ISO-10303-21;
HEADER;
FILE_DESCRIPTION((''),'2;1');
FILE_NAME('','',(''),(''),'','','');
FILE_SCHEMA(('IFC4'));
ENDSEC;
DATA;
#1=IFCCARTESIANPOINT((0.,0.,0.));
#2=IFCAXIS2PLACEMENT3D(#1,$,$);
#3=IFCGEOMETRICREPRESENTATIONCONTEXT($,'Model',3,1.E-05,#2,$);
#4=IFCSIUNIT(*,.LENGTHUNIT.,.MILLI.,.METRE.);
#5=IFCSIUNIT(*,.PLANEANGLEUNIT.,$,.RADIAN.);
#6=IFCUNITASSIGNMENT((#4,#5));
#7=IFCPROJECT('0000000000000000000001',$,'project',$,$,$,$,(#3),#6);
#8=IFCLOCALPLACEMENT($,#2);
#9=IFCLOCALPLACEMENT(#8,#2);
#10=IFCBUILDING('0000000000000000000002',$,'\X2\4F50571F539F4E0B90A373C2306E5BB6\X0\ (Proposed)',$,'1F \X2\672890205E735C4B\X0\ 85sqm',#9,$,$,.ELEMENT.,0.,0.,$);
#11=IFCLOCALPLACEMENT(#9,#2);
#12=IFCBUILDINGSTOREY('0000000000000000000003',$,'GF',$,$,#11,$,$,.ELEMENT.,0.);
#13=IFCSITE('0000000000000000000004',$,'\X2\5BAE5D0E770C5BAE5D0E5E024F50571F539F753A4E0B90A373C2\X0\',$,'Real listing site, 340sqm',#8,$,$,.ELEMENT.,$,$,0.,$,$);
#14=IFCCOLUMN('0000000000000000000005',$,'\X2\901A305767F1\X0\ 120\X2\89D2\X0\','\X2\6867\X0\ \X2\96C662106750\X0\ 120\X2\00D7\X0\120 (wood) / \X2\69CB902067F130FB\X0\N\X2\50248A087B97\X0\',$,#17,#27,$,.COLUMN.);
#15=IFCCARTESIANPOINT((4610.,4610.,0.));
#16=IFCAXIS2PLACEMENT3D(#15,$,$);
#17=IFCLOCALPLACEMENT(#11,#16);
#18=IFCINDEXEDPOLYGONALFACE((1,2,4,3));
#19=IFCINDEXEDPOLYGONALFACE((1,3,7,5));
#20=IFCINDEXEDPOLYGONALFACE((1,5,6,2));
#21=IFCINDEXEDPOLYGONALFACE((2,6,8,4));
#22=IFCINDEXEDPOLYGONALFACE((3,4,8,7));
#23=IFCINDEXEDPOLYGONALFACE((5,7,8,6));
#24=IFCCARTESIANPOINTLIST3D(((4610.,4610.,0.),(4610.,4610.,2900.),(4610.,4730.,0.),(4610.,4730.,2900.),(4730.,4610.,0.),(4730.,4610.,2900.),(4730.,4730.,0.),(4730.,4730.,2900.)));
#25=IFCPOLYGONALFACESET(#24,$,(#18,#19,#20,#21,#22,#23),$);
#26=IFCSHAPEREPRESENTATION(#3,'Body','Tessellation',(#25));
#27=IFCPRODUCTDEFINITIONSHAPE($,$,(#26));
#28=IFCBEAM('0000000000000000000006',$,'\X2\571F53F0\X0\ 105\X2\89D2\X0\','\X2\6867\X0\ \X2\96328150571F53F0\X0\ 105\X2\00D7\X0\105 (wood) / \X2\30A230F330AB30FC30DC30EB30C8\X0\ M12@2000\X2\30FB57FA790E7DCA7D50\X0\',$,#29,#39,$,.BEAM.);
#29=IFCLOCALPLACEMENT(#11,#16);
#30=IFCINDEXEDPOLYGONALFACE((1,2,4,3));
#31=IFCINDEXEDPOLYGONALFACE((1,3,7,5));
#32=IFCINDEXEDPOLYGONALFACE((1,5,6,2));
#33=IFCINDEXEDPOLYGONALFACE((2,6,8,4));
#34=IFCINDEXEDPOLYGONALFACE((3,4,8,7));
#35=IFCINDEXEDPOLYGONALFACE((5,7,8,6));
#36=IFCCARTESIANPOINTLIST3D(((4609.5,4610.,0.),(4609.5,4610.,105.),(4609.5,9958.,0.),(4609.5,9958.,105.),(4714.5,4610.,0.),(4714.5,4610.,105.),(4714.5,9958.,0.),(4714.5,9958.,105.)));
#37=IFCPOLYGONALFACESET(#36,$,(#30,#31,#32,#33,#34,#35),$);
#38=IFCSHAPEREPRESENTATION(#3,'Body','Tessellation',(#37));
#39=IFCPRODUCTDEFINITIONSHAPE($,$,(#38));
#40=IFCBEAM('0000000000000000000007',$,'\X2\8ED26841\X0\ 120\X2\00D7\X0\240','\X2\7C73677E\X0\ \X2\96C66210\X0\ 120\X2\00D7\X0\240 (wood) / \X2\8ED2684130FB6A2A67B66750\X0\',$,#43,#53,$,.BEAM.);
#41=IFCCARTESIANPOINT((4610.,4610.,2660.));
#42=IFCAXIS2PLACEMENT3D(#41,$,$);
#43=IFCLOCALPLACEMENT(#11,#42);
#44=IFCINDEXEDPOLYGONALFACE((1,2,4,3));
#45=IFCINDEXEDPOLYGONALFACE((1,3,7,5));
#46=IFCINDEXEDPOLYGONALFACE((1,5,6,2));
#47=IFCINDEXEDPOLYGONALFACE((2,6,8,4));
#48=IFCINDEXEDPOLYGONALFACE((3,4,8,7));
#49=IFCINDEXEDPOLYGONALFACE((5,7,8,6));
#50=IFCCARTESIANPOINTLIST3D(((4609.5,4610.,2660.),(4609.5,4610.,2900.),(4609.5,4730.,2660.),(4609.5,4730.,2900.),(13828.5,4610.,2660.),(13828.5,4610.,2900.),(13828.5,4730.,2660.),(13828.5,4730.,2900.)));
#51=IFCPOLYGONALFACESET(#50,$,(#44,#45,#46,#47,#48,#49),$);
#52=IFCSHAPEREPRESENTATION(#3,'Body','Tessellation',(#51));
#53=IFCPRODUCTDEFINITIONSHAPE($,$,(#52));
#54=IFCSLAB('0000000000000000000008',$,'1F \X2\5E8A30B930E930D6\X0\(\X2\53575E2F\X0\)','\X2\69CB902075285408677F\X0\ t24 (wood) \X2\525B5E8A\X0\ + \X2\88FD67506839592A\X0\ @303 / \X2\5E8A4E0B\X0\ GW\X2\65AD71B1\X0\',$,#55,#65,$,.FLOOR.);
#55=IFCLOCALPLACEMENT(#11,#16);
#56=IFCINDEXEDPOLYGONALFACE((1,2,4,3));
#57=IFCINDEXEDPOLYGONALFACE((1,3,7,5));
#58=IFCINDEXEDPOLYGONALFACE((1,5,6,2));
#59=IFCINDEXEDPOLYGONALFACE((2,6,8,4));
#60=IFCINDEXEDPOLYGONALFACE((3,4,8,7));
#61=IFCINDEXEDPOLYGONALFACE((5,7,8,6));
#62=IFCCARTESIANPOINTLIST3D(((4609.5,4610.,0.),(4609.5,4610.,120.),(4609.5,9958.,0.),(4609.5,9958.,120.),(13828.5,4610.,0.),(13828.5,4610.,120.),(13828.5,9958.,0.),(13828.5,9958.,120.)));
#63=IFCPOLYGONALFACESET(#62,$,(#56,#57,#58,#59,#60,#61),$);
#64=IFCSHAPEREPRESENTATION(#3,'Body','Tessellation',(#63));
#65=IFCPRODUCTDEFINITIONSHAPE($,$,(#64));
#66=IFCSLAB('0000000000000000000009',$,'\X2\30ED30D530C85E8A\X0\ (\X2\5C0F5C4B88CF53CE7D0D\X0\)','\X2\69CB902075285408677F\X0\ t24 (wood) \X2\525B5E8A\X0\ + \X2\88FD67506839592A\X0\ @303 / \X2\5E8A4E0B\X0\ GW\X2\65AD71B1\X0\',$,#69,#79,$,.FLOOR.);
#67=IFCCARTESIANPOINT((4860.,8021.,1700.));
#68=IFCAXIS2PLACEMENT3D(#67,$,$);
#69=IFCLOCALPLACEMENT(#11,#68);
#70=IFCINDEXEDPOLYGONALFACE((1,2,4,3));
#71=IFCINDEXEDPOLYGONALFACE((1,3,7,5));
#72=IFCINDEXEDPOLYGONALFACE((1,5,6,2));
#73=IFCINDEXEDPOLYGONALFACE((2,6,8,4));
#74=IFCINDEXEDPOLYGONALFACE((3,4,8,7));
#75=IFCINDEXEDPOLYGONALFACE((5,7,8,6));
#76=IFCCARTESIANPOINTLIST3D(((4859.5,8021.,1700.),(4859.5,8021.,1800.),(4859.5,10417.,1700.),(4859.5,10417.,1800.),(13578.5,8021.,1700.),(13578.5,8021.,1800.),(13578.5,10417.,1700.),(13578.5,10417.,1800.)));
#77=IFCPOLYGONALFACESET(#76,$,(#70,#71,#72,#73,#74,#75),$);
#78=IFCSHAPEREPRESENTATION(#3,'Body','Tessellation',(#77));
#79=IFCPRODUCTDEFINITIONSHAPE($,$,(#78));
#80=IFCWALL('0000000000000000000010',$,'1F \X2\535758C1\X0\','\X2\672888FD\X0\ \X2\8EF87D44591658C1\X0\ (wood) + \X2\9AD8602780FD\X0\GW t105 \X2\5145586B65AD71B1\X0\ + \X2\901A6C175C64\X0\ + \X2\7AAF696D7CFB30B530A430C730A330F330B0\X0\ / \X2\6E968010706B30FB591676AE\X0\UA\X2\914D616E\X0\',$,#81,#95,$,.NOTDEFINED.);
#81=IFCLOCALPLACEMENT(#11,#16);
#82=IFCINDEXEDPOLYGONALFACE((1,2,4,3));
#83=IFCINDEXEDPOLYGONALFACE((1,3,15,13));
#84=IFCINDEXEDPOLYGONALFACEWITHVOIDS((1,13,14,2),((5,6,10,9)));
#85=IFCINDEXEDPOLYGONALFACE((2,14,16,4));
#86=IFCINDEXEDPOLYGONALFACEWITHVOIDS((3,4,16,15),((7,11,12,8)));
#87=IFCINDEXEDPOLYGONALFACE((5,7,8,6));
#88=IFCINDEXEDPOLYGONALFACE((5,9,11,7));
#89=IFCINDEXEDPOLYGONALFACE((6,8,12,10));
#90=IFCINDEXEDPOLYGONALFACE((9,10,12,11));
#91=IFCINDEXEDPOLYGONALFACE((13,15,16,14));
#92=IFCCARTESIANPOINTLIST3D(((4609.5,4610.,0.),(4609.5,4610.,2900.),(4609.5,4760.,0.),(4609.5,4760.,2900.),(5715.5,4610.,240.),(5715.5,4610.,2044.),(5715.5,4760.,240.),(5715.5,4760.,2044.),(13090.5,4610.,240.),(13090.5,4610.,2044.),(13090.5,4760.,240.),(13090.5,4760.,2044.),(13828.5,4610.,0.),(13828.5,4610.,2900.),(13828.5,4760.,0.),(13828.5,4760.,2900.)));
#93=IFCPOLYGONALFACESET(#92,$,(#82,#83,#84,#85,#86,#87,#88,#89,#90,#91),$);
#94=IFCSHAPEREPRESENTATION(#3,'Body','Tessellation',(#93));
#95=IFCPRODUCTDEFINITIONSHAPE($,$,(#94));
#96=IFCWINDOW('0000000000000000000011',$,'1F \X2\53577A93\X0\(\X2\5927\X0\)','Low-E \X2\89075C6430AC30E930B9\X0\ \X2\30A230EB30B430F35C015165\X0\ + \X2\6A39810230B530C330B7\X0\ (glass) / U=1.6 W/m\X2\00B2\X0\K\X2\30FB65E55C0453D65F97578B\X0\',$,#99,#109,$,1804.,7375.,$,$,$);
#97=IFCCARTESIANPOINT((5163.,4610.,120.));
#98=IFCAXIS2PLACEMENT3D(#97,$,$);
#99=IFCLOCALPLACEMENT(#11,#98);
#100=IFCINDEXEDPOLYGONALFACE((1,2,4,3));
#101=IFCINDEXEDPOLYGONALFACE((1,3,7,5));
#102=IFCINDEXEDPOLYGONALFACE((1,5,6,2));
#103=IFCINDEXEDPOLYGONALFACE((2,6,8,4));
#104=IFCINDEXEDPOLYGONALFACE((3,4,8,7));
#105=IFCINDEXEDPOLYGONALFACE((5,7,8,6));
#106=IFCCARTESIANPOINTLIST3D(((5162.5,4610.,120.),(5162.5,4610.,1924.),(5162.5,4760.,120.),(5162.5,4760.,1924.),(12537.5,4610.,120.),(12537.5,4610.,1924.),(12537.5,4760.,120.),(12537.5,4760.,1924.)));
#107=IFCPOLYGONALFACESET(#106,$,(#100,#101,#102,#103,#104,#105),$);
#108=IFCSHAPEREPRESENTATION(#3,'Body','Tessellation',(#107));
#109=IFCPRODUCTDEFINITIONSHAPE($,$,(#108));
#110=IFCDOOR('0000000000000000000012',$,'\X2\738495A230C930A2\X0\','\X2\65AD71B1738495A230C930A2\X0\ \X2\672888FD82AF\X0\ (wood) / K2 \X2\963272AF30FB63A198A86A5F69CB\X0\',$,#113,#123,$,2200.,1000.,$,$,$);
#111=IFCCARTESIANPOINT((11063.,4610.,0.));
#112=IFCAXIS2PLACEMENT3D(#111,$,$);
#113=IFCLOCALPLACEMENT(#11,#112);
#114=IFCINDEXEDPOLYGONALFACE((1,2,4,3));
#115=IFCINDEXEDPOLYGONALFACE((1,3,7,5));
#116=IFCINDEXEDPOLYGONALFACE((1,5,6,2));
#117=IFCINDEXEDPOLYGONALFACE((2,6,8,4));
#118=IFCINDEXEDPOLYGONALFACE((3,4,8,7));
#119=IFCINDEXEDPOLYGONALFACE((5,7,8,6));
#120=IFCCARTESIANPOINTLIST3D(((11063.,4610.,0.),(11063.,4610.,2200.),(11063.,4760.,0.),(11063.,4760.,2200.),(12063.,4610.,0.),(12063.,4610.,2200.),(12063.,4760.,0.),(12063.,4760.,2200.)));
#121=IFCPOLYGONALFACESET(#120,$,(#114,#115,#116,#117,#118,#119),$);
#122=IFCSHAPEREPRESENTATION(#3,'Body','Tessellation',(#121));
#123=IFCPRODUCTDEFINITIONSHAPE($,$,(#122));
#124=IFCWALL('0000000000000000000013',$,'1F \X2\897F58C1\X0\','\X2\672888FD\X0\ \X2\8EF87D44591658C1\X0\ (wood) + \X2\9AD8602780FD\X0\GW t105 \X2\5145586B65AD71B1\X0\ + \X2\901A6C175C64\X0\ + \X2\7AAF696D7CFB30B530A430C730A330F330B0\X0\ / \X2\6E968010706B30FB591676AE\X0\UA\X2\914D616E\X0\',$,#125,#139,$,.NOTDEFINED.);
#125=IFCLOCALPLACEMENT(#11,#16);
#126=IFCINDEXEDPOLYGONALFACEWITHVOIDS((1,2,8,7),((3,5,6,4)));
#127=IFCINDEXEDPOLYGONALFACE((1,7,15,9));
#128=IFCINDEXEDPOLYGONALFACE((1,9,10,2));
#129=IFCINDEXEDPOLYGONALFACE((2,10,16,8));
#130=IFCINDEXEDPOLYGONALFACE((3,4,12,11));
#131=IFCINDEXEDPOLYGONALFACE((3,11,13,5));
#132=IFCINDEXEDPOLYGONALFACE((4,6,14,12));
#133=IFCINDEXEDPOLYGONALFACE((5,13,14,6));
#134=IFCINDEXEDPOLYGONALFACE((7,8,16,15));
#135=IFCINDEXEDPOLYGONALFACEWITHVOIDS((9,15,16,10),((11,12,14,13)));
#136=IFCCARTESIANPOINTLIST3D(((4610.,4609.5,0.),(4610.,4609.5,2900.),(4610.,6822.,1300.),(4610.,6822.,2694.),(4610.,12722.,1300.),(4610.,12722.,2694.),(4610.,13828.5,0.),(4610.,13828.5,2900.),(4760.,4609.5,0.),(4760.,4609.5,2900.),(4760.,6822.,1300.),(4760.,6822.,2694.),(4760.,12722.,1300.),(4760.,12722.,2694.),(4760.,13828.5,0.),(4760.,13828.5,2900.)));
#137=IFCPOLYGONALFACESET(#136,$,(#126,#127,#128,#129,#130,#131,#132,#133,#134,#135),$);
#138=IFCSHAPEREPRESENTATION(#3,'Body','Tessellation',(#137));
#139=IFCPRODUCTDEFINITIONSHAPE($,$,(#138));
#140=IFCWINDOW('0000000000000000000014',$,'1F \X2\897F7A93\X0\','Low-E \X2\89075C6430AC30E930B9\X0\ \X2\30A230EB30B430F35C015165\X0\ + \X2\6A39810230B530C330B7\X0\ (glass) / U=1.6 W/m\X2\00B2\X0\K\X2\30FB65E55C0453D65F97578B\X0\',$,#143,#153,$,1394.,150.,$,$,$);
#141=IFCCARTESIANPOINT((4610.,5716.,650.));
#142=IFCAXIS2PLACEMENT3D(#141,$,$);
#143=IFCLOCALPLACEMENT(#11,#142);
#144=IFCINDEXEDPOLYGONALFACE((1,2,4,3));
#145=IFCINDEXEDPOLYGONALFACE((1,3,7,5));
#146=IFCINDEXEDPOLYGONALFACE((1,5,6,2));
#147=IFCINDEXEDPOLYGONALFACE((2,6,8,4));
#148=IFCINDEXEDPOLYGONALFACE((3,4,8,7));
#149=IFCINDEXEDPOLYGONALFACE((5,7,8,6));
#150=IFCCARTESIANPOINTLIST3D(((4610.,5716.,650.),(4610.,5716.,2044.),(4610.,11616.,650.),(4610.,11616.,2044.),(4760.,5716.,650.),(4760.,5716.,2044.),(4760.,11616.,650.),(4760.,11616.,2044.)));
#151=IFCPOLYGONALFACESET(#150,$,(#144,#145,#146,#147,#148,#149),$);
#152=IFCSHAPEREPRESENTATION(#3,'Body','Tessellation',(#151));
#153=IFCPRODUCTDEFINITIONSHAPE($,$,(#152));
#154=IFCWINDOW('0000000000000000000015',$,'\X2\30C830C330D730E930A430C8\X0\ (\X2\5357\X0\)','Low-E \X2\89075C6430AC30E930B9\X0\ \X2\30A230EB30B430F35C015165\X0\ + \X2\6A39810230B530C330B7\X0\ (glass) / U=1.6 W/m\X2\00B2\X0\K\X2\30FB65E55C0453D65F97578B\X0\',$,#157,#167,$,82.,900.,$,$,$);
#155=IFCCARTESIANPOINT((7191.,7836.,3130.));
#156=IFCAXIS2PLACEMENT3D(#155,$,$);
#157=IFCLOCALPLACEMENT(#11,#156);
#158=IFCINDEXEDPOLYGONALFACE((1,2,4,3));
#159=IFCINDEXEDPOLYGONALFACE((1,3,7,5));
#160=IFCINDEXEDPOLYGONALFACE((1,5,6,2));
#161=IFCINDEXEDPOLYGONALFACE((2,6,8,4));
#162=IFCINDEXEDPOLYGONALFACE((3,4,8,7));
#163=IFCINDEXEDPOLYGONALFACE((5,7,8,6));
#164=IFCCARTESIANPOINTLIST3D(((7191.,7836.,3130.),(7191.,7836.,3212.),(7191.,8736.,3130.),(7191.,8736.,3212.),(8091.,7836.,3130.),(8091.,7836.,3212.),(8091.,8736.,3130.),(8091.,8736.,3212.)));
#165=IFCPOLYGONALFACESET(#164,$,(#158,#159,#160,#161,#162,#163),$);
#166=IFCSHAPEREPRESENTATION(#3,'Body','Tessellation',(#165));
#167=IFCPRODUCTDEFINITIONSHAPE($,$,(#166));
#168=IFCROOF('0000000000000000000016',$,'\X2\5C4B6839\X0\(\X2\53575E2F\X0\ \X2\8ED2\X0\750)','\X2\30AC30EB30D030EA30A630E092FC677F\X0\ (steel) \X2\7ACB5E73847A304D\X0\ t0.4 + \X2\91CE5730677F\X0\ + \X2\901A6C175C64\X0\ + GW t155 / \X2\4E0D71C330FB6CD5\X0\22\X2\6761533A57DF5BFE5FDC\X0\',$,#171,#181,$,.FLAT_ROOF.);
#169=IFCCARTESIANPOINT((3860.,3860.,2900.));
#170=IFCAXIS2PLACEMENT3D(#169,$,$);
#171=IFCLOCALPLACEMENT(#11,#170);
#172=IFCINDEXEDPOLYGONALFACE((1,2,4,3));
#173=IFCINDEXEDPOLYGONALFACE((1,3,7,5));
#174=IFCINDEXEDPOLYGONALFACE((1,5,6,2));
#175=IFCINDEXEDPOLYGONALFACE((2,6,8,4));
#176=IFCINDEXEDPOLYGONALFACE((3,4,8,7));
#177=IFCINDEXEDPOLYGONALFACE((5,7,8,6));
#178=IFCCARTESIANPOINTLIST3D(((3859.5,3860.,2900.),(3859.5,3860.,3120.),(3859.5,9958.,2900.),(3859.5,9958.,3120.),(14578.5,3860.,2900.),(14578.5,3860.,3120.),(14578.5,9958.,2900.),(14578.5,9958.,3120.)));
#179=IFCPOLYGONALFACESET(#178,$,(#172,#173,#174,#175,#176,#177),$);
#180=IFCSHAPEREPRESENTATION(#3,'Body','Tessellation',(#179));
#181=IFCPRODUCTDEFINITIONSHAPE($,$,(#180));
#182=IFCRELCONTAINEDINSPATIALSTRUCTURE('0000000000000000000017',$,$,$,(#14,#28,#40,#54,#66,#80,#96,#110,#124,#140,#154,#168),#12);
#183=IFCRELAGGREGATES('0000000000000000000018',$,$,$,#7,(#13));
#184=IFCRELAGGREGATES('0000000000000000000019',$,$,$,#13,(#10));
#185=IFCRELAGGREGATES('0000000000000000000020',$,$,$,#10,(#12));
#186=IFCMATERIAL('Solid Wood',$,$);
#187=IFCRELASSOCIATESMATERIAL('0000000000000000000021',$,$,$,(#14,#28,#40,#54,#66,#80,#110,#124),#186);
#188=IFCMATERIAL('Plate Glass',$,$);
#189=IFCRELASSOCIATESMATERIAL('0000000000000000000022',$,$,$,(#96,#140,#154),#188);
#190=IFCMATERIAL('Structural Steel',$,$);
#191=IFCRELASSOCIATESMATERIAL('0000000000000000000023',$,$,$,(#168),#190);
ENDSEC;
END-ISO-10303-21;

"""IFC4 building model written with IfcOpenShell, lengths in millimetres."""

from ifc_helpers import new_model, si_unit, frame, frame_2d, origin, place, context, project, spatial, rectangle, extrude, material, element, fill, save


model = new_model("IFC4")

# Units and contexts
model_context = context("Model", 3, precision=1e-05, world=origin())
ifc_project = project(units=[si_unit("LENGTHUNIT", "METRE", prefix="MILLI"), si_unit("PLANEANGLEUNIT", "RADIAN")], contexts=[model_context])

# Site, building, storey
site_placement = place(None, origin())
site = spatial("IfcSite", under=ifc_project, at=site_placement, Name="宮崎県宮崎市佐土原町下那珂", ObjectType="Real listing site, 340sqm", CompositionType="ELEMENT", RefElevation=0.0)
building_placement = place(site_placement, origin())
building = spatial("IfcBuilding", under=site, at=building_placement, Name="佐土原下那珂の家 (Proposed)", ObjectType="1F 木造平屋 85sqm", CompositionType="ELEMENT", ElevationOfRefHeight=0.0, ElevationOfTerrain=0.0)
storey_placement = place(building_placement, origin())
storey = spatial("IfcBuildingStorey", under=building, at=storey_placement, Name="GF", CompositionType="ELEMENT", Elevation=0.0)

# Column
ifc_material_1 = material(Name="Solid Wood")
column_1_placement = place(storey_placement, frame((4610.0, 4610.0, 0.0)))
element("IfcColumn", 1, at=column_1_placement, inside=storey, material=ifc_material_1, Name="通し柱 120角", Description="桧 集成材 120×120 (wood) / 構造柱・N値計算", PredefinedType="COLUMN", context=model_context, shape_type="SweptSolid", body=[
    extrude(rectangle(XDim=120.0, YDim=120.0, at=frame_2d((60.0, 60.0))), frame((4610.0, 4610.0, 0.0)), (0.0, 0.0, 1.0), 2900.0),
])

# Beams
beam_1_placement = place(storey_placement, frame((4610.0, 4610.0, 0.0)))
element("IfcBeam", 2, at=beam_1_placement, inside=storey, material=ifc_material_1, Name="土台 105角", Description="桧 防腐土台 105×105 (wood) / アンカーボルト M12@2000・基礎緊結", PredefinedType="BEAM", context=model_context, shape_type="SweptSolid", body=[
    extrude(rectangle(XDim=105.0, YDim=5348.0, at=frame_2d((52.0, 2674.0))), frame((4610.0, 4610.0, 0.0)), (0.0, 0.0, 1.0), 105.0),
])
beam_2_placement = place(storey_placement, frame((4610.0, 4610.0, 2660.0)))
element("IfcBeam", 3, at=beam_2_placement, inside=storey, material=ifc_material_1, Name="軒桁 120×240", Description="米松 集成 120×240 (wood) / 軒桁・横架材", PredefinedType="BEAM", context=model_context, shape_type="SweptSolid", body=[
    extrude(rectangle(XDim=9219.0, YDim=120.0, at=frame_2d((4609.0, 60.0))), frame((4610.0, 4610.0, 2660.0)), (0.0, 0.0, 1.0), 240.0),
])

# Slabs
slab_1_placement = place(storey_placement, frame((4610.0, 4610.0, 0.0)))
element("IfcSlab", 4, at=slab_1_placement, inside=storey, material=ifc_material_1, Name="1F 床スラブ(南帯)", Description="構造用合板 t24 (wood) 剛床 + 製材根太 @303 / 床下 GW断熱", PredefinedType="FLOOR", context=model_context, shape_type="SweptSolid", body=[
    extrude(rectangle(XDim=9219.0, YDim=5348.0, at=frame_2d((4609.0, 2674.0))), frame((4610.0, 4610.0, 0.0)), (0.0, 0.0, 1.0), 120.0),
])
slab_2_placement = place(storey_placement, frame((4860.0, 8021.0, 1700.0)))
element("IfcSlab", 5, at=slab_2_placement, inside=storey, material=ifc_material_1, Name="ロフト床 (小屋裏収納)", Description="構造用合板 t24 (wood) 剛床 + 製材根太 @303 / 床下 GW断熱", PredefinedType="FLOOR", context=model_context, shape_type="SweptSolid", body=[
    extrude(rectangle(XDim=8719.0, YDim=2396.0, at=frame_2d((4359.0, 1198.0))), frame((4860.0, 8021.0, 1700.0)), (0.0, 0.0, 1.0), 100.0),
])

# Wall, openings, window, door
wall_1_placement = place(storey_placement, frame((4610.0, 4610.0, 0.0)))
wall_1 = element("IfcWall", 6, at=wall_1_placement, inside=storey, material=ifc_material_1, Name="1F 南壁", Description="木製 軸組外壁 (wood) + 高性能GW t105 充填断熱 + 通気層 + 窯業系サイディング / 準耐火・外皮UA配慮", PredefinedType="NOTDEFINED", context=model_context, shape_type="SweptSolid", body=[
    extrude(rectangle(XDim=9219.0, YDim=150.0, at=frame_2d((4609.0, 75.0))), frame((4610.0, 4610.0, 0.0)), (0.0, 0.0, 1.0), 2900.0),
])
opening_1_placement = place(storey_placement, frame((5163.0, 4610.0, 120.0)))
opening_1 = element("IfcOpeningElement", 7, at=opening_1_placement, cuts=wall_1, PredefinedType="NOTDEFINED", context=model_context, shape_type="SweptSolid", body=[
    extrude(rectangle(XDim=7375.0, YDim=150.0, at=frame_2d((3687.0, 75.0))), frame((5163.0, 4610.0, 120.0)), (0.0, 0.0, 1.0), 1804.0),
])
opening_2_placement = place(storey_placement, frame((11063.0, 4610.0, 0.0)))
opening_2 = element("IfcOpeningElement", 8, at=opening_2_placement, cuts=wall_1, PredefinedType="NOTDEFINED", context=model_context, shape_type="SweptSolid", body=[
    extrude(rectangle(XDim=1000.0, YDim=150.0, at=frame_2d((500.0, 75.0))), frame((11063.0, 4610.0, 0.0)), (0.0, 0.0, 1.0), 2200.0),
])
ifc_material_2 = material(Name="Plate Glass")
window_1_placement = place(storey_placement, frame((5163.0, 4610.0, 120.0)))
window_1 = element("IfcWindow", 9, at=window_1_placement, inside=storey, material=ifc_material_2, Name="1F 南窓(大)", Description="Low-E 複層ガラス アルゴン封入 + 樹脂サッシ (glass) / U=1.6 W/m²K・日射取得型", OverallHeight=1804.0, OverallWidth=7375.0, context=model_context, shape_type="SweptSolid", body=[
    extrude(rectangle(XDim=7375.0, YDim=150.0, at=frame_2d((3687.0, 75.0))), frame((5163.0, 4610.0, 120.0)), (0.0, 0.0, 1.0), 1804.0),
])
fill(opening_1, window_1)
door_1_placement = place(storey_placement, frame((11063.0, 4610.0, 0.0)))
door_1 = element("IfcDoor", 10, at=door_1_placement, inside=storey, material=ifc_material_1, Name="玄関ドア", Description="断熱玄関ドア 木製芯 (wood) / K2 防犯・採風機構", OverallHeight=2200.0, OverallWidth=1000.0, context=model_context, shape_type="SweptSolid", body=[
    extrude(rectangle(XDim=1000.0, YDim=150.0, at=frame_2d((500.0, 75.0))), frame((11063.0, 4610.0, 0.0)), (0.0, 0.0, 1.0), 2200.0),
])
fill(opening_2, door_1)

# Wall, opening, window
wall_2_placement = place(storey_placement, frame((4610.0, 4610.0, 0.0)))
wall_2 = element("IfcWall", 11, at=wall_2_placement, inside=storey, material=ifc_material_1, Name="1F 西壁", Description="木製 軸組外壁 (wood) + 高性能GW t105 充填断熱 + 通気層 + 窯業系サイディング / 準耐火・外皮UA配慮", PredefinedType="NOTDEFINED", context=model_context, shape_type="SweptSolid", body=[
    extrude(rectangle(XDim=150.0, YDim=9219.0, at=frame_2d((75.0, 4609.0))), frame((4610.0, 4610.0, 0.0)), (0.0, 0.0, 1.0), 2900.0),
])
opening_3_placement = place(storey_placement, frame((4610.0, 5716.0, 650.0)))
opening_3 = element("IfcOpeningElement", 12, at=opening_3_placement, cuts=wall_2, PredefinedType="NOTDEFINED", context=model_context, shape_type="SweptSolid", body=[
    extrude(rectangle(XDim=150.0, YDim=5900.0, at=frame_2d((75.0, 2950.0))), frame((4610.0, 5716.0, 650.0)), (0.0, 0.0, 1.0), 1394.0),
])
window_2_placement = place(storey_placement, frame((4610.0, 5716.0, 650.0)))
window_2 = element("IfcWindow", 13, at=window_2_placement, inside=storey, material=ifc_material_2, Name="1F 西窓", Description="Low-E 複層ガラス アルゴン封入 + 樹脂サッシ (glass) / U=1.6 W/m²K・日射取得型", OverallHeight=1394.0, OverallWidth=150.0, context=model_context, shape_type="SweptSolid", body=[
    extrude(rectangle(XDim=150.0, YDim=5900.0, at=frame_2d((75.0, 2950.0))), frame((4610.0, 5716.0, 650.0)), (0.0, 0.0, 1.0), 1394.0),
])
fill(opening_3, window_2)

# Window
window_3_placement = place(storey_placement, frame((7191.0, 7836.0, 3130.0)))
element("IfcWindow", 14, at=window_3_placement, inside=storey, material=ifc_material_2, Name="トップライト (南)", Description="Low-E 複層ガラス アルゴン封入 + 樹脂サッシ (glass) / U=1.6 W/m²K・日射取得型", OverallHeight=82.0, OverallWidth=900.0, context=model_context, shape_type="SweptSolid", body=[
    extrude(rectangle(XDim=900.0, YDim=900.0, at=frame_2d((450.0, 450.0))), frame((7191.0, 7836.0, 3130.0)), (0.0, 0.0, 1.0), 82.0),
])

# Roof
ifc_material_3 = material(Name="Structural Steel")
roof_placement = place(storey_placement, frame((3860.0, 3860.0, 2900.0)))
element("IfcRoof", 15, at=roof_placement, inside=storey, material=ifc_material_3, Name="屋根(南帯 軒750)", Description="ガルバリウム鋼板 (steel) 立平葺き t0.4 + 野地板 + 通気層 + GW t155 / 不燃・法22条区域対応", PredefinedType="FLAT_ROOF", context=model_context, shape_type="SweptSolid", body=[
    extrude(rectangle(XDim=10719.0, YDim=6098.0, at=frame_2d((5359.0, 3049.0))), frame((3860.0, 3860.0, 2900.0)), (0.0, 0.0, 1.0), 220.0),
])

save(model, "model.ifc")
